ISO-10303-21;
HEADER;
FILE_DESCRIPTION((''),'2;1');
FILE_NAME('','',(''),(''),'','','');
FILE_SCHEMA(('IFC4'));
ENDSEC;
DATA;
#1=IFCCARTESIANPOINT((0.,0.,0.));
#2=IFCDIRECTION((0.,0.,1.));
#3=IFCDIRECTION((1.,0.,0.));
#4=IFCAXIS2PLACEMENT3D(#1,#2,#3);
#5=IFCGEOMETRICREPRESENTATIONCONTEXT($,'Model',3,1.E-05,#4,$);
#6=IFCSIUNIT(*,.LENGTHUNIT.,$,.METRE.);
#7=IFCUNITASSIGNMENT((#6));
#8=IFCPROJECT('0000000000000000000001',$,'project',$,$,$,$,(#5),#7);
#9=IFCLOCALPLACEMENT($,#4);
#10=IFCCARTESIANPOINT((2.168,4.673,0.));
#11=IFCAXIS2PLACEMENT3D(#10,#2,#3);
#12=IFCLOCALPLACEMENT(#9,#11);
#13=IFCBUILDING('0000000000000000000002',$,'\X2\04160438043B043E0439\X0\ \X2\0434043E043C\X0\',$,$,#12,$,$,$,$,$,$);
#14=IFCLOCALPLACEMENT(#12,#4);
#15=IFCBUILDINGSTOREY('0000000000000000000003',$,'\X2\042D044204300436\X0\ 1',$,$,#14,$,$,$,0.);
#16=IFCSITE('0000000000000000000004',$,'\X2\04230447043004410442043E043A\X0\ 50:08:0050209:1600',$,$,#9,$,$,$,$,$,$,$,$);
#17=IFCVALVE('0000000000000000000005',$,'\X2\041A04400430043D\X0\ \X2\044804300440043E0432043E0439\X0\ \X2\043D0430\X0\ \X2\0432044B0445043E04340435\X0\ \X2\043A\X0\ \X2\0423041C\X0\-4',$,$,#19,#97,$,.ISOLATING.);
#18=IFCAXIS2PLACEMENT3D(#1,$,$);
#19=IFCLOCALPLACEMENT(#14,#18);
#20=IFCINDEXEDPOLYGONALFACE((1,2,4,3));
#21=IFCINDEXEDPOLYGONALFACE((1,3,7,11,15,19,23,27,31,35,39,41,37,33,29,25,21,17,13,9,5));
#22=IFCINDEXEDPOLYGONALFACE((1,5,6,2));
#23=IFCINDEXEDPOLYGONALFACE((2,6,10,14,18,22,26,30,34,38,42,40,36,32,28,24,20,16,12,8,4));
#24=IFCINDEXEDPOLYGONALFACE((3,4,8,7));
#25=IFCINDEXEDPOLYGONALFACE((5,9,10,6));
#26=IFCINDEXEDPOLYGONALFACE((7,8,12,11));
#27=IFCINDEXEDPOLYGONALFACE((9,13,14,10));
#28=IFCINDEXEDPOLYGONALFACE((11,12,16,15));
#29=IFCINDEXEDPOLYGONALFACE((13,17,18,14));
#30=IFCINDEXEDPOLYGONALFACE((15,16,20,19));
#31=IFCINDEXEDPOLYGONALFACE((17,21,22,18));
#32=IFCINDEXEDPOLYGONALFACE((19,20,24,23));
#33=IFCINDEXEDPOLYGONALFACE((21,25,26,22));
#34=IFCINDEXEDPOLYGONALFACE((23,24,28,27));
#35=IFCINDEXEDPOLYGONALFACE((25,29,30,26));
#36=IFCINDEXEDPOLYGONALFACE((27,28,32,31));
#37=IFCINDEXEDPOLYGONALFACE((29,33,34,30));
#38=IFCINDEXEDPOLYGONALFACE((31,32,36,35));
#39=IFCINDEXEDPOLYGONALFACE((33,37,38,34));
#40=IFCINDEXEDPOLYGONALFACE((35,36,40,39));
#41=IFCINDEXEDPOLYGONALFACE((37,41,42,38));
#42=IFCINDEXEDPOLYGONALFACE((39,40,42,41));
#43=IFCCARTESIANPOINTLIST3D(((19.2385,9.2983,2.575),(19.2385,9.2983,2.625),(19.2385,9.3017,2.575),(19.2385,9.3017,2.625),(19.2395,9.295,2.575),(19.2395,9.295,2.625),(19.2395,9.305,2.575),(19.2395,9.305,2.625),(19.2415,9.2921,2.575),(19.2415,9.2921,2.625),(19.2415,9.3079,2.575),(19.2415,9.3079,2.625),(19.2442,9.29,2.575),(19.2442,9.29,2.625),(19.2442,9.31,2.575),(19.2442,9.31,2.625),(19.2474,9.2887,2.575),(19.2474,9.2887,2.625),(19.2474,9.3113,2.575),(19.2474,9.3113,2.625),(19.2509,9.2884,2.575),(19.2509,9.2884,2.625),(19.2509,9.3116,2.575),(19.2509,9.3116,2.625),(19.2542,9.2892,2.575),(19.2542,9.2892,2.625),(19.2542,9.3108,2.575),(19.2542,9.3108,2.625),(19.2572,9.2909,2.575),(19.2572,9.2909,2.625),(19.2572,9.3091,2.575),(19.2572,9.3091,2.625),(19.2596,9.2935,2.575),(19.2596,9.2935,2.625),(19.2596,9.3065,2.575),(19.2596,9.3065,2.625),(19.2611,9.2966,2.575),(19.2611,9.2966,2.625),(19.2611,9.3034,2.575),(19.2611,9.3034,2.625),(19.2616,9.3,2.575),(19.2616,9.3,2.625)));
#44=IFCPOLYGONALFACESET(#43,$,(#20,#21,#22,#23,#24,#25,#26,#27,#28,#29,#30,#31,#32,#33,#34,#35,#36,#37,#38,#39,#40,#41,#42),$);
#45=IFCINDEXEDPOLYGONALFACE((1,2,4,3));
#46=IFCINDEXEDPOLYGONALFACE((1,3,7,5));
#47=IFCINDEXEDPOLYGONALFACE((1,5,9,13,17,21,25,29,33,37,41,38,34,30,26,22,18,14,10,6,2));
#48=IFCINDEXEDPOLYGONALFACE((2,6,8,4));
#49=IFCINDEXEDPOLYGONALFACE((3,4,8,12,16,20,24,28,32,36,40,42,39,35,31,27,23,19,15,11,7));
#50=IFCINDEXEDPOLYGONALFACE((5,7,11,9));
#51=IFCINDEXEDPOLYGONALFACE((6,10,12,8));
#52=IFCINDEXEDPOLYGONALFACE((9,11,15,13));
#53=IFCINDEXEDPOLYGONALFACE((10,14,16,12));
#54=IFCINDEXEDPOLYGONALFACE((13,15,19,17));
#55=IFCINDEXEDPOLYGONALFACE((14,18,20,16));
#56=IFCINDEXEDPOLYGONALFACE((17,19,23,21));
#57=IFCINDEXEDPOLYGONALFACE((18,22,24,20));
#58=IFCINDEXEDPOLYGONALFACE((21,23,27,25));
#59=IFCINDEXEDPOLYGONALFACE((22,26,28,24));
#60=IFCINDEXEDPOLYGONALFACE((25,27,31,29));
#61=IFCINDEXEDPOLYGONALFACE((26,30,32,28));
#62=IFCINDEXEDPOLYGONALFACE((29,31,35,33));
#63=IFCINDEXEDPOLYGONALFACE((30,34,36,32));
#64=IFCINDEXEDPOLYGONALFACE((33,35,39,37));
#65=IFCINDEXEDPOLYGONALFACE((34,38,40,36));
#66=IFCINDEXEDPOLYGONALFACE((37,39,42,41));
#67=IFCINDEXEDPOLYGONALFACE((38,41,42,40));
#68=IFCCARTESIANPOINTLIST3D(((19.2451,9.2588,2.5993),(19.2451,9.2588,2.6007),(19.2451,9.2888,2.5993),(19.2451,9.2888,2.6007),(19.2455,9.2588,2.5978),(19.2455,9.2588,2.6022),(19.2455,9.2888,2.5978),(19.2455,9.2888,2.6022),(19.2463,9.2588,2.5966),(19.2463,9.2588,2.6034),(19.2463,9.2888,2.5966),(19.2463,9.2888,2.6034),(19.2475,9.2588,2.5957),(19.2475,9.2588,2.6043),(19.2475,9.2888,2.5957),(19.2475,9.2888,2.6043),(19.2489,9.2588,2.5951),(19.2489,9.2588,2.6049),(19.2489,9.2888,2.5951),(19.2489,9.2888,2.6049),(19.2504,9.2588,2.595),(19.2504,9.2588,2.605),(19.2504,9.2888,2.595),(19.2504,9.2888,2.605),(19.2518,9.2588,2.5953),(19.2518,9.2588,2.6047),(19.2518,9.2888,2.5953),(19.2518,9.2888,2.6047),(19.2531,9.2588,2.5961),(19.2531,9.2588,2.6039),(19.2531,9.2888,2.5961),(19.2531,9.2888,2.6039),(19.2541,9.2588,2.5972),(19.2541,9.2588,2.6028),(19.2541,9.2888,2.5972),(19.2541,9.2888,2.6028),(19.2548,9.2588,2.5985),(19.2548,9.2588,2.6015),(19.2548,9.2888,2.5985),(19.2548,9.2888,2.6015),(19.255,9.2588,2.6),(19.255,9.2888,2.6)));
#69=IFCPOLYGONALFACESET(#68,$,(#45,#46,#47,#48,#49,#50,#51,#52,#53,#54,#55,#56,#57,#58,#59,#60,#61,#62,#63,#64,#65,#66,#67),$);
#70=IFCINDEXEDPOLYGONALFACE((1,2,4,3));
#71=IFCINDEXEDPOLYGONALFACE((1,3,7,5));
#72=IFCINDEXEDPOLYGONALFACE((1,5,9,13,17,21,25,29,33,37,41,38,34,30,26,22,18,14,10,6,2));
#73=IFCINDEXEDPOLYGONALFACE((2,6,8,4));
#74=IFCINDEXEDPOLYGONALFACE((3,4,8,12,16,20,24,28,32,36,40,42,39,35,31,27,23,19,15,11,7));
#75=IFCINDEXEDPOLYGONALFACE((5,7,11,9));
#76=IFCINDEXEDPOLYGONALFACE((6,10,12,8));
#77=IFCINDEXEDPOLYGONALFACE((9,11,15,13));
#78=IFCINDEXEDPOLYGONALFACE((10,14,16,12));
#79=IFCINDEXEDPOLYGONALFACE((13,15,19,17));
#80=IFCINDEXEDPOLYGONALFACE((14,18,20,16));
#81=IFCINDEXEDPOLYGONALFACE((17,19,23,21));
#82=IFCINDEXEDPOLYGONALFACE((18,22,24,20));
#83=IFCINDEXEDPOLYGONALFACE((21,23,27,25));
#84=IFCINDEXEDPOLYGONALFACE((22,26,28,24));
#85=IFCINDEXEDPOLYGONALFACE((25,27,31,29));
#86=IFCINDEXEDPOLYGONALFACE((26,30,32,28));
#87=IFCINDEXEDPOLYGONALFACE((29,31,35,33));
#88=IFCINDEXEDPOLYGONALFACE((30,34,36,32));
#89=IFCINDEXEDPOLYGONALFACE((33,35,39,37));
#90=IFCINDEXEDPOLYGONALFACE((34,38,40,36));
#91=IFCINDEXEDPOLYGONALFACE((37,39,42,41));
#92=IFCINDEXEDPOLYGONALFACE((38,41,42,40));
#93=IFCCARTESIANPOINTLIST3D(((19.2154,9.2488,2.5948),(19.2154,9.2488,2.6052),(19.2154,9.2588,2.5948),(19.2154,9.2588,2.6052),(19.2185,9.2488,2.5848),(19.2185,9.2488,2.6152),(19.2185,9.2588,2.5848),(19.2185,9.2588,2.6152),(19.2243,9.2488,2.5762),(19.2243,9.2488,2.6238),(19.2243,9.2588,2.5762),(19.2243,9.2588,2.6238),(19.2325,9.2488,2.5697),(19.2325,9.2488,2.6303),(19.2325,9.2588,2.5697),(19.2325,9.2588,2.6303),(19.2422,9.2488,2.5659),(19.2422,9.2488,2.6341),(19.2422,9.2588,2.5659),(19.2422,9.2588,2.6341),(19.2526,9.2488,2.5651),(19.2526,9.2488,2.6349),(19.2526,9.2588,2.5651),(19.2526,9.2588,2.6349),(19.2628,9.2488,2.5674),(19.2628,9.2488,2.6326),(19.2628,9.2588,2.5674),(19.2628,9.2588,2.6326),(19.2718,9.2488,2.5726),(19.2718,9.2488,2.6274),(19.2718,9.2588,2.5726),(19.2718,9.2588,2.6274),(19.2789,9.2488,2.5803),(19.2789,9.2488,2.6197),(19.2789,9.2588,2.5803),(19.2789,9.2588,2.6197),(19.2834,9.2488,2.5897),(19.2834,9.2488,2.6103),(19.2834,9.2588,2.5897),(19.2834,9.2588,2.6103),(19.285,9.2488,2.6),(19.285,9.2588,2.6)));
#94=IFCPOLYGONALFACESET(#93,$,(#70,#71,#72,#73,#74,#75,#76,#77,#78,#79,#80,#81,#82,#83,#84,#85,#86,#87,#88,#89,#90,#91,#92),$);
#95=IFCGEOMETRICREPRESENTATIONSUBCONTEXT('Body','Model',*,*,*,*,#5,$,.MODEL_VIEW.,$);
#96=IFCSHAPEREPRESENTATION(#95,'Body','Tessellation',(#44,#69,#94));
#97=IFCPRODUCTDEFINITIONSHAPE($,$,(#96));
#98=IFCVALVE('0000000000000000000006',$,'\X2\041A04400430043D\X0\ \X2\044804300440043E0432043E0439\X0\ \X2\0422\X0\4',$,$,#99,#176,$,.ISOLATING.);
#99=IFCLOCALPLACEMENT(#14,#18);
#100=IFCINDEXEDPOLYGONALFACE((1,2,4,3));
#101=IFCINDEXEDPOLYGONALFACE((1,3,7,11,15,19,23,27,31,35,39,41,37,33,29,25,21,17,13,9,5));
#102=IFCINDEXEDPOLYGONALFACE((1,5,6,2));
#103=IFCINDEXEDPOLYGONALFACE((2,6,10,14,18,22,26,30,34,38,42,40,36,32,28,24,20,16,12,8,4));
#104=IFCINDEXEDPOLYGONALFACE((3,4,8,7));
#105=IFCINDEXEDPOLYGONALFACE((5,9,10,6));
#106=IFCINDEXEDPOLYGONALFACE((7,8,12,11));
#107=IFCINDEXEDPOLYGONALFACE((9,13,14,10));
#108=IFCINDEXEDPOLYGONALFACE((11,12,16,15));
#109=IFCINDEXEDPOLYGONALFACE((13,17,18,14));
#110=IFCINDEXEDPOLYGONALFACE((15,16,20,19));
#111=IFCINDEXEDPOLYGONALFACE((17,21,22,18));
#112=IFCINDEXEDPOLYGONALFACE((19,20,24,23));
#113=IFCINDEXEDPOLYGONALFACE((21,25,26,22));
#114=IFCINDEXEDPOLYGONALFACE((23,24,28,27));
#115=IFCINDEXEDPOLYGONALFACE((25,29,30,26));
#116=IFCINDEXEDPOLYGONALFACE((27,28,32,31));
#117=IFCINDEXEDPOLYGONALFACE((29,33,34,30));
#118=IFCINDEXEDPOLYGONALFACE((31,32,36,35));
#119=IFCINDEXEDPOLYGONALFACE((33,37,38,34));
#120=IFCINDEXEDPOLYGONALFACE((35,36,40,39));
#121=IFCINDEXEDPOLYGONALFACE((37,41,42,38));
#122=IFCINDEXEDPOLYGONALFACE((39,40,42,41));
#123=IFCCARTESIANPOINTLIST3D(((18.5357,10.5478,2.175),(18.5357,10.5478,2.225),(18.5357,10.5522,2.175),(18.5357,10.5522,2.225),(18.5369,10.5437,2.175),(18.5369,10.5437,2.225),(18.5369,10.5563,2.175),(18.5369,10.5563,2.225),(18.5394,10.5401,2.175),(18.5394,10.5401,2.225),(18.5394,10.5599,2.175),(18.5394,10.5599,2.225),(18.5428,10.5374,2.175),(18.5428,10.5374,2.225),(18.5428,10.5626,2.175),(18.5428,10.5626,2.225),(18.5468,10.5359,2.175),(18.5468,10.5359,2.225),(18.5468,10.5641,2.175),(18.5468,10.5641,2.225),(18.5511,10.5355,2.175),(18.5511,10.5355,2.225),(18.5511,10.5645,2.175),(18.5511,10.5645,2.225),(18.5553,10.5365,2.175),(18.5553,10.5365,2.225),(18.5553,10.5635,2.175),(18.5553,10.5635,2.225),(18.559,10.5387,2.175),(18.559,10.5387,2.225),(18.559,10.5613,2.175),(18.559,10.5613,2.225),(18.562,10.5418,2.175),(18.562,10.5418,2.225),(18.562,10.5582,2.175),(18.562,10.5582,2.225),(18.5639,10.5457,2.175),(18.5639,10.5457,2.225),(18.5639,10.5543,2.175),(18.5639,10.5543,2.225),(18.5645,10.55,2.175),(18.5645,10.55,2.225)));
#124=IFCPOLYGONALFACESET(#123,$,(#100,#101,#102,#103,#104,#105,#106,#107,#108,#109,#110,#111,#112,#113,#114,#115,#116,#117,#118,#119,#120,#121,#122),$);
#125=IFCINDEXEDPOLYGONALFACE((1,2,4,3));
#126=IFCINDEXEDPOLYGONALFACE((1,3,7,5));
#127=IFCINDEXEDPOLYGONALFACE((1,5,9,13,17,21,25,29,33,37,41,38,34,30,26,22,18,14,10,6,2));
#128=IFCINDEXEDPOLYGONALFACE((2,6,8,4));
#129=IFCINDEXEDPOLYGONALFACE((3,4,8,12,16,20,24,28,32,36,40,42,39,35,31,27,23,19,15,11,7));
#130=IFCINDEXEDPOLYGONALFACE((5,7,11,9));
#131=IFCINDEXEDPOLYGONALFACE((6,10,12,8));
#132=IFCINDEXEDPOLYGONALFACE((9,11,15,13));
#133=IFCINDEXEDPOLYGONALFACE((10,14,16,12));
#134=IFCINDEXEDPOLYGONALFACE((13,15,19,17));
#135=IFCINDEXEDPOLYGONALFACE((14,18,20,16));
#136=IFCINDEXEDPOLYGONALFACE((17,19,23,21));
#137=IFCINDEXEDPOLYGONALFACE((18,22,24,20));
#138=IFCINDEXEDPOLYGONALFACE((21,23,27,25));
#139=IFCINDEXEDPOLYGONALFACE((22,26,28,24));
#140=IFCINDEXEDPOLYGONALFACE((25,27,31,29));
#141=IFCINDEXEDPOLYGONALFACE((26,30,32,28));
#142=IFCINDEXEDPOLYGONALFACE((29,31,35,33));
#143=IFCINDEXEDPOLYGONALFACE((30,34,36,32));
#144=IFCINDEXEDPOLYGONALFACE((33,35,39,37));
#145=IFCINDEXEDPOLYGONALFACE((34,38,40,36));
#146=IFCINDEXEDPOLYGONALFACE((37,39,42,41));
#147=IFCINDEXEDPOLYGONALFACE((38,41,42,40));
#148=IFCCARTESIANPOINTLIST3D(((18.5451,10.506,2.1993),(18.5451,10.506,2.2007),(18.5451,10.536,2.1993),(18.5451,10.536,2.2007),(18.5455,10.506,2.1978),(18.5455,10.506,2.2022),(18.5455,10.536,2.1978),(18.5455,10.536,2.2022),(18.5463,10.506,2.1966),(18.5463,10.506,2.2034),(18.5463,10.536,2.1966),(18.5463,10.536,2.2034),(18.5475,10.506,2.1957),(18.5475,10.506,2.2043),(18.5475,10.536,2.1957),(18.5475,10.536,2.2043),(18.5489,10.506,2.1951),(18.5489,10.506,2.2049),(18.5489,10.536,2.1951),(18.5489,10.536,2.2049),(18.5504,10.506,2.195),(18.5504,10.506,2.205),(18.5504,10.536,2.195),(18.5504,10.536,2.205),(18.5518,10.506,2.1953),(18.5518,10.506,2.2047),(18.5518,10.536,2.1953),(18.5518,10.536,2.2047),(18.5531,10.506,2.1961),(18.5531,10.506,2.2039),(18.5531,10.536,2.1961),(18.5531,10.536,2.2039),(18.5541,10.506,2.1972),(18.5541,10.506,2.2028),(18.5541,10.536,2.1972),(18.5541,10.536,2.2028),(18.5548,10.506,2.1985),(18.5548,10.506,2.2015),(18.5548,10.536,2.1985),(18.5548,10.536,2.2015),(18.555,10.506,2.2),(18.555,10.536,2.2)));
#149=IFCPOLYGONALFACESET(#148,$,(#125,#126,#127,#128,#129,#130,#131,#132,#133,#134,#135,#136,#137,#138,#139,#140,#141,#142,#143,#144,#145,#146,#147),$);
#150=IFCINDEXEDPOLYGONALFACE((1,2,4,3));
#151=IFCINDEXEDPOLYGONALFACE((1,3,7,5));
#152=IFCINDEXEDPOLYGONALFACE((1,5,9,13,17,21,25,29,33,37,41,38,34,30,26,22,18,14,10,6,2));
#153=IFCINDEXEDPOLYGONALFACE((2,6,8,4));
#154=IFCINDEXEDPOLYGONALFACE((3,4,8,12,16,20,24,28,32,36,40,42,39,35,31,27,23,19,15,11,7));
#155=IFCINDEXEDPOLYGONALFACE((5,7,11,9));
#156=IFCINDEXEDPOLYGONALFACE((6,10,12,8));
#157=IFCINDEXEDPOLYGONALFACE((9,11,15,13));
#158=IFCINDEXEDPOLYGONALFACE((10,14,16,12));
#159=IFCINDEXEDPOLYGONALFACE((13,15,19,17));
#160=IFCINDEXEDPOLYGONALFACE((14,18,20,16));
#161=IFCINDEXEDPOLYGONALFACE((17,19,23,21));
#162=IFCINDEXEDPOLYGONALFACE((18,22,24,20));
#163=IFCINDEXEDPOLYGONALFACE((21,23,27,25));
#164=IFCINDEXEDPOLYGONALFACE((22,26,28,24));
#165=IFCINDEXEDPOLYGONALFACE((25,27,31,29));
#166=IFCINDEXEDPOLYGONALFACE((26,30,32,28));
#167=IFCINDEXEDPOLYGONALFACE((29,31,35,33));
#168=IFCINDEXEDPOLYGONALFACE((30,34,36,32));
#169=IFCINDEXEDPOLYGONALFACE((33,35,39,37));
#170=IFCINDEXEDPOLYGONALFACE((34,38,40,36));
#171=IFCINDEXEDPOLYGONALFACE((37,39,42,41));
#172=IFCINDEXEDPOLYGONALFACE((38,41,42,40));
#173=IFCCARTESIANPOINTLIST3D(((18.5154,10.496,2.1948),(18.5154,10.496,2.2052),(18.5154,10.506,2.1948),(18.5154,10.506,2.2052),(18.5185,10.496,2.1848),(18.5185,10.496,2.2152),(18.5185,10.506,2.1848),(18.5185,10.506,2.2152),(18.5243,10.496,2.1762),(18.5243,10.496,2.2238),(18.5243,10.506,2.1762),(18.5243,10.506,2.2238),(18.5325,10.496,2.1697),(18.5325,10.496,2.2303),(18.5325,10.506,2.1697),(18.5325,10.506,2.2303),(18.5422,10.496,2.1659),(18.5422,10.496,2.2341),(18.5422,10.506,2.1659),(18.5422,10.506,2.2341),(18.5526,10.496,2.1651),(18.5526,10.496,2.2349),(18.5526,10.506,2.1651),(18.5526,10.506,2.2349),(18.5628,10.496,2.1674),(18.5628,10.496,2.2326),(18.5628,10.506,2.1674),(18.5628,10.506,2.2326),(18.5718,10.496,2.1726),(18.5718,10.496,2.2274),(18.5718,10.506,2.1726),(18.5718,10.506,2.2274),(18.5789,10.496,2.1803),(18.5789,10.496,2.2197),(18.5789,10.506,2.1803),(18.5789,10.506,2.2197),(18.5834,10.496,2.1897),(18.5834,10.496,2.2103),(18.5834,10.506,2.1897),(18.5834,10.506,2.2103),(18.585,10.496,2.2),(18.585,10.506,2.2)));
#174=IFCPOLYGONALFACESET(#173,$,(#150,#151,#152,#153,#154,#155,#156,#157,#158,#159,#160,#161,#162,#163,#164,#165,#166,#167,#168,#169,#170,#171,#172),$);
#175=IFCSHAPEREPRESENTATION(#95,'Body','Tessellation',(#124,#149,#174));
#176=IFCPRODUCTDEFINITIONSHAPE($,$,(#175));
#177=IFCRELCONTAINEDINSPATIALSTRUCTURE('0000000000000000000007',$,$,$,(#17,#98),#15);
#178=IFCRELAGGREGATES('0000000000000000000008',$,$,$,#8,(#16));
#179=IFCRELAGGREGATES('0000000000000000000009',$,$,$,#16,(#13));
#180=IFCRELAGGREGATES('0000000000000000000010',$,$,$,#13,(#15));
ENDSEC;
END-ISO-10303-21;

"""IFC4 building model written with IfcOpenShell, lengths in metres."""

from ifc_helpers import new_model, si_unit, frame, origin_with_axes, origin_2d, place, context, subcontext, project, spatial, circle, extrude, element, save


model = new_model("IFC4")

# Units and contexts
model_context = context("Model", 3, precision=1e-05, world=origin_with_axes())
body_context = subcontext(model_context, "Body", "Model", "MODEL_VIEW")
ifc_project = project(units=[si_unit("LENGTHUNIT", "METRE")], contexts=[model_context])

# Site, building, storey
site_placement = place(None, origin_with_axes())
site = spatial("IfcSite", under=ifc_project, at=site_placement, Name="Участок 50:08:0050209:1600")
building_placement = place(site_placement, frame((2.168, 4.673, 0.0), z_axis=(0.0, 0.0, 1.0), x_axis=(1.0, 0.0, 0.0)))
building = spatial("IfcBuilding", under=site, at=building_placement, Name="Жилой дом")
storey_placement = place(building_placement, origin_with_axes())
storey = spatial("IfcBuildingStorey", under=building, at=storey_placement, Name="Этаж 1", Elevation=0.0)

# Valves
valve_1_placement = place(storey_placement, origin_with_axes())
element("IfcValve", 1, at=valve_1_placement, inside=storey, Name="Кран шаровой на выходе к УМ-4", PredefinedType="ISOLATING", context=body_context, shape_type="SweptSolid", body=[
    extrude(circle(Radius=0.0116, at=origin_2d()), frame((19.25, 9.3, 2.575), z_axis=(0.0, 0.0, 1.0), x_axis=(1.0, 0.0, 0.0)), (0.0, 0.0, 1.0), 0.05),
    extrude(circle(Radius=0.005, at=origin_2d()), frame((19.25, 9.2888, 2.6), z_axis=(0.0, -1.0, 0.0), x_axis=(1.0, 0.0, 0.0)), (0.0, 0.0, 1.0), 0.03),
    extrude(circle(Radius=0.035, at=origin_2d()), frame((19.25, 9.2588, 2.6), z_axis=(0.0, -1.0, 0.0), x_axis=(1.0, 0.0, 0.0)), (0.0, 0.0, 1.0), 0.01),
])
valve_2_placement = place(storey_placement, origin_with_axes())
element("IfcValve", 2, at=valve_2_placement, inside=storey, Name="Кран шаровой Т4", PredefinedType="ISOLATING", context=body_context, shape_type="SweptSolid", body=[
    extrude(circle(Radius=0.0145, at=origin_2d()), frame((18.55, 10.55, 2.175), z_axis=(0.0, 0.0, 1.0), x_axis=(1.0, 0.0, 0.0)), (0.0, 0.0, 1.0), 0.05),
    extrude(circle(Radius=0.005, at=origin_2d()), frame((18.55, 10.536, 2.2), z_axis=(0.0, -1.0, 0.0), x_axis=(1.0, 0.0, 0.0)), (0.0, 0.0, 1.0), 0.03),
    extrude(circle(Radius=0.035, at=origin_2d()), frame((18.55, 10.506, 2.2), z_axis=(0.0, -1.0, 0.0), x_axis=(1.0, 0.0, 0.0)), (0.0, 0.0, 1.0), 0.01),
])

save(model, "model.ifc")
